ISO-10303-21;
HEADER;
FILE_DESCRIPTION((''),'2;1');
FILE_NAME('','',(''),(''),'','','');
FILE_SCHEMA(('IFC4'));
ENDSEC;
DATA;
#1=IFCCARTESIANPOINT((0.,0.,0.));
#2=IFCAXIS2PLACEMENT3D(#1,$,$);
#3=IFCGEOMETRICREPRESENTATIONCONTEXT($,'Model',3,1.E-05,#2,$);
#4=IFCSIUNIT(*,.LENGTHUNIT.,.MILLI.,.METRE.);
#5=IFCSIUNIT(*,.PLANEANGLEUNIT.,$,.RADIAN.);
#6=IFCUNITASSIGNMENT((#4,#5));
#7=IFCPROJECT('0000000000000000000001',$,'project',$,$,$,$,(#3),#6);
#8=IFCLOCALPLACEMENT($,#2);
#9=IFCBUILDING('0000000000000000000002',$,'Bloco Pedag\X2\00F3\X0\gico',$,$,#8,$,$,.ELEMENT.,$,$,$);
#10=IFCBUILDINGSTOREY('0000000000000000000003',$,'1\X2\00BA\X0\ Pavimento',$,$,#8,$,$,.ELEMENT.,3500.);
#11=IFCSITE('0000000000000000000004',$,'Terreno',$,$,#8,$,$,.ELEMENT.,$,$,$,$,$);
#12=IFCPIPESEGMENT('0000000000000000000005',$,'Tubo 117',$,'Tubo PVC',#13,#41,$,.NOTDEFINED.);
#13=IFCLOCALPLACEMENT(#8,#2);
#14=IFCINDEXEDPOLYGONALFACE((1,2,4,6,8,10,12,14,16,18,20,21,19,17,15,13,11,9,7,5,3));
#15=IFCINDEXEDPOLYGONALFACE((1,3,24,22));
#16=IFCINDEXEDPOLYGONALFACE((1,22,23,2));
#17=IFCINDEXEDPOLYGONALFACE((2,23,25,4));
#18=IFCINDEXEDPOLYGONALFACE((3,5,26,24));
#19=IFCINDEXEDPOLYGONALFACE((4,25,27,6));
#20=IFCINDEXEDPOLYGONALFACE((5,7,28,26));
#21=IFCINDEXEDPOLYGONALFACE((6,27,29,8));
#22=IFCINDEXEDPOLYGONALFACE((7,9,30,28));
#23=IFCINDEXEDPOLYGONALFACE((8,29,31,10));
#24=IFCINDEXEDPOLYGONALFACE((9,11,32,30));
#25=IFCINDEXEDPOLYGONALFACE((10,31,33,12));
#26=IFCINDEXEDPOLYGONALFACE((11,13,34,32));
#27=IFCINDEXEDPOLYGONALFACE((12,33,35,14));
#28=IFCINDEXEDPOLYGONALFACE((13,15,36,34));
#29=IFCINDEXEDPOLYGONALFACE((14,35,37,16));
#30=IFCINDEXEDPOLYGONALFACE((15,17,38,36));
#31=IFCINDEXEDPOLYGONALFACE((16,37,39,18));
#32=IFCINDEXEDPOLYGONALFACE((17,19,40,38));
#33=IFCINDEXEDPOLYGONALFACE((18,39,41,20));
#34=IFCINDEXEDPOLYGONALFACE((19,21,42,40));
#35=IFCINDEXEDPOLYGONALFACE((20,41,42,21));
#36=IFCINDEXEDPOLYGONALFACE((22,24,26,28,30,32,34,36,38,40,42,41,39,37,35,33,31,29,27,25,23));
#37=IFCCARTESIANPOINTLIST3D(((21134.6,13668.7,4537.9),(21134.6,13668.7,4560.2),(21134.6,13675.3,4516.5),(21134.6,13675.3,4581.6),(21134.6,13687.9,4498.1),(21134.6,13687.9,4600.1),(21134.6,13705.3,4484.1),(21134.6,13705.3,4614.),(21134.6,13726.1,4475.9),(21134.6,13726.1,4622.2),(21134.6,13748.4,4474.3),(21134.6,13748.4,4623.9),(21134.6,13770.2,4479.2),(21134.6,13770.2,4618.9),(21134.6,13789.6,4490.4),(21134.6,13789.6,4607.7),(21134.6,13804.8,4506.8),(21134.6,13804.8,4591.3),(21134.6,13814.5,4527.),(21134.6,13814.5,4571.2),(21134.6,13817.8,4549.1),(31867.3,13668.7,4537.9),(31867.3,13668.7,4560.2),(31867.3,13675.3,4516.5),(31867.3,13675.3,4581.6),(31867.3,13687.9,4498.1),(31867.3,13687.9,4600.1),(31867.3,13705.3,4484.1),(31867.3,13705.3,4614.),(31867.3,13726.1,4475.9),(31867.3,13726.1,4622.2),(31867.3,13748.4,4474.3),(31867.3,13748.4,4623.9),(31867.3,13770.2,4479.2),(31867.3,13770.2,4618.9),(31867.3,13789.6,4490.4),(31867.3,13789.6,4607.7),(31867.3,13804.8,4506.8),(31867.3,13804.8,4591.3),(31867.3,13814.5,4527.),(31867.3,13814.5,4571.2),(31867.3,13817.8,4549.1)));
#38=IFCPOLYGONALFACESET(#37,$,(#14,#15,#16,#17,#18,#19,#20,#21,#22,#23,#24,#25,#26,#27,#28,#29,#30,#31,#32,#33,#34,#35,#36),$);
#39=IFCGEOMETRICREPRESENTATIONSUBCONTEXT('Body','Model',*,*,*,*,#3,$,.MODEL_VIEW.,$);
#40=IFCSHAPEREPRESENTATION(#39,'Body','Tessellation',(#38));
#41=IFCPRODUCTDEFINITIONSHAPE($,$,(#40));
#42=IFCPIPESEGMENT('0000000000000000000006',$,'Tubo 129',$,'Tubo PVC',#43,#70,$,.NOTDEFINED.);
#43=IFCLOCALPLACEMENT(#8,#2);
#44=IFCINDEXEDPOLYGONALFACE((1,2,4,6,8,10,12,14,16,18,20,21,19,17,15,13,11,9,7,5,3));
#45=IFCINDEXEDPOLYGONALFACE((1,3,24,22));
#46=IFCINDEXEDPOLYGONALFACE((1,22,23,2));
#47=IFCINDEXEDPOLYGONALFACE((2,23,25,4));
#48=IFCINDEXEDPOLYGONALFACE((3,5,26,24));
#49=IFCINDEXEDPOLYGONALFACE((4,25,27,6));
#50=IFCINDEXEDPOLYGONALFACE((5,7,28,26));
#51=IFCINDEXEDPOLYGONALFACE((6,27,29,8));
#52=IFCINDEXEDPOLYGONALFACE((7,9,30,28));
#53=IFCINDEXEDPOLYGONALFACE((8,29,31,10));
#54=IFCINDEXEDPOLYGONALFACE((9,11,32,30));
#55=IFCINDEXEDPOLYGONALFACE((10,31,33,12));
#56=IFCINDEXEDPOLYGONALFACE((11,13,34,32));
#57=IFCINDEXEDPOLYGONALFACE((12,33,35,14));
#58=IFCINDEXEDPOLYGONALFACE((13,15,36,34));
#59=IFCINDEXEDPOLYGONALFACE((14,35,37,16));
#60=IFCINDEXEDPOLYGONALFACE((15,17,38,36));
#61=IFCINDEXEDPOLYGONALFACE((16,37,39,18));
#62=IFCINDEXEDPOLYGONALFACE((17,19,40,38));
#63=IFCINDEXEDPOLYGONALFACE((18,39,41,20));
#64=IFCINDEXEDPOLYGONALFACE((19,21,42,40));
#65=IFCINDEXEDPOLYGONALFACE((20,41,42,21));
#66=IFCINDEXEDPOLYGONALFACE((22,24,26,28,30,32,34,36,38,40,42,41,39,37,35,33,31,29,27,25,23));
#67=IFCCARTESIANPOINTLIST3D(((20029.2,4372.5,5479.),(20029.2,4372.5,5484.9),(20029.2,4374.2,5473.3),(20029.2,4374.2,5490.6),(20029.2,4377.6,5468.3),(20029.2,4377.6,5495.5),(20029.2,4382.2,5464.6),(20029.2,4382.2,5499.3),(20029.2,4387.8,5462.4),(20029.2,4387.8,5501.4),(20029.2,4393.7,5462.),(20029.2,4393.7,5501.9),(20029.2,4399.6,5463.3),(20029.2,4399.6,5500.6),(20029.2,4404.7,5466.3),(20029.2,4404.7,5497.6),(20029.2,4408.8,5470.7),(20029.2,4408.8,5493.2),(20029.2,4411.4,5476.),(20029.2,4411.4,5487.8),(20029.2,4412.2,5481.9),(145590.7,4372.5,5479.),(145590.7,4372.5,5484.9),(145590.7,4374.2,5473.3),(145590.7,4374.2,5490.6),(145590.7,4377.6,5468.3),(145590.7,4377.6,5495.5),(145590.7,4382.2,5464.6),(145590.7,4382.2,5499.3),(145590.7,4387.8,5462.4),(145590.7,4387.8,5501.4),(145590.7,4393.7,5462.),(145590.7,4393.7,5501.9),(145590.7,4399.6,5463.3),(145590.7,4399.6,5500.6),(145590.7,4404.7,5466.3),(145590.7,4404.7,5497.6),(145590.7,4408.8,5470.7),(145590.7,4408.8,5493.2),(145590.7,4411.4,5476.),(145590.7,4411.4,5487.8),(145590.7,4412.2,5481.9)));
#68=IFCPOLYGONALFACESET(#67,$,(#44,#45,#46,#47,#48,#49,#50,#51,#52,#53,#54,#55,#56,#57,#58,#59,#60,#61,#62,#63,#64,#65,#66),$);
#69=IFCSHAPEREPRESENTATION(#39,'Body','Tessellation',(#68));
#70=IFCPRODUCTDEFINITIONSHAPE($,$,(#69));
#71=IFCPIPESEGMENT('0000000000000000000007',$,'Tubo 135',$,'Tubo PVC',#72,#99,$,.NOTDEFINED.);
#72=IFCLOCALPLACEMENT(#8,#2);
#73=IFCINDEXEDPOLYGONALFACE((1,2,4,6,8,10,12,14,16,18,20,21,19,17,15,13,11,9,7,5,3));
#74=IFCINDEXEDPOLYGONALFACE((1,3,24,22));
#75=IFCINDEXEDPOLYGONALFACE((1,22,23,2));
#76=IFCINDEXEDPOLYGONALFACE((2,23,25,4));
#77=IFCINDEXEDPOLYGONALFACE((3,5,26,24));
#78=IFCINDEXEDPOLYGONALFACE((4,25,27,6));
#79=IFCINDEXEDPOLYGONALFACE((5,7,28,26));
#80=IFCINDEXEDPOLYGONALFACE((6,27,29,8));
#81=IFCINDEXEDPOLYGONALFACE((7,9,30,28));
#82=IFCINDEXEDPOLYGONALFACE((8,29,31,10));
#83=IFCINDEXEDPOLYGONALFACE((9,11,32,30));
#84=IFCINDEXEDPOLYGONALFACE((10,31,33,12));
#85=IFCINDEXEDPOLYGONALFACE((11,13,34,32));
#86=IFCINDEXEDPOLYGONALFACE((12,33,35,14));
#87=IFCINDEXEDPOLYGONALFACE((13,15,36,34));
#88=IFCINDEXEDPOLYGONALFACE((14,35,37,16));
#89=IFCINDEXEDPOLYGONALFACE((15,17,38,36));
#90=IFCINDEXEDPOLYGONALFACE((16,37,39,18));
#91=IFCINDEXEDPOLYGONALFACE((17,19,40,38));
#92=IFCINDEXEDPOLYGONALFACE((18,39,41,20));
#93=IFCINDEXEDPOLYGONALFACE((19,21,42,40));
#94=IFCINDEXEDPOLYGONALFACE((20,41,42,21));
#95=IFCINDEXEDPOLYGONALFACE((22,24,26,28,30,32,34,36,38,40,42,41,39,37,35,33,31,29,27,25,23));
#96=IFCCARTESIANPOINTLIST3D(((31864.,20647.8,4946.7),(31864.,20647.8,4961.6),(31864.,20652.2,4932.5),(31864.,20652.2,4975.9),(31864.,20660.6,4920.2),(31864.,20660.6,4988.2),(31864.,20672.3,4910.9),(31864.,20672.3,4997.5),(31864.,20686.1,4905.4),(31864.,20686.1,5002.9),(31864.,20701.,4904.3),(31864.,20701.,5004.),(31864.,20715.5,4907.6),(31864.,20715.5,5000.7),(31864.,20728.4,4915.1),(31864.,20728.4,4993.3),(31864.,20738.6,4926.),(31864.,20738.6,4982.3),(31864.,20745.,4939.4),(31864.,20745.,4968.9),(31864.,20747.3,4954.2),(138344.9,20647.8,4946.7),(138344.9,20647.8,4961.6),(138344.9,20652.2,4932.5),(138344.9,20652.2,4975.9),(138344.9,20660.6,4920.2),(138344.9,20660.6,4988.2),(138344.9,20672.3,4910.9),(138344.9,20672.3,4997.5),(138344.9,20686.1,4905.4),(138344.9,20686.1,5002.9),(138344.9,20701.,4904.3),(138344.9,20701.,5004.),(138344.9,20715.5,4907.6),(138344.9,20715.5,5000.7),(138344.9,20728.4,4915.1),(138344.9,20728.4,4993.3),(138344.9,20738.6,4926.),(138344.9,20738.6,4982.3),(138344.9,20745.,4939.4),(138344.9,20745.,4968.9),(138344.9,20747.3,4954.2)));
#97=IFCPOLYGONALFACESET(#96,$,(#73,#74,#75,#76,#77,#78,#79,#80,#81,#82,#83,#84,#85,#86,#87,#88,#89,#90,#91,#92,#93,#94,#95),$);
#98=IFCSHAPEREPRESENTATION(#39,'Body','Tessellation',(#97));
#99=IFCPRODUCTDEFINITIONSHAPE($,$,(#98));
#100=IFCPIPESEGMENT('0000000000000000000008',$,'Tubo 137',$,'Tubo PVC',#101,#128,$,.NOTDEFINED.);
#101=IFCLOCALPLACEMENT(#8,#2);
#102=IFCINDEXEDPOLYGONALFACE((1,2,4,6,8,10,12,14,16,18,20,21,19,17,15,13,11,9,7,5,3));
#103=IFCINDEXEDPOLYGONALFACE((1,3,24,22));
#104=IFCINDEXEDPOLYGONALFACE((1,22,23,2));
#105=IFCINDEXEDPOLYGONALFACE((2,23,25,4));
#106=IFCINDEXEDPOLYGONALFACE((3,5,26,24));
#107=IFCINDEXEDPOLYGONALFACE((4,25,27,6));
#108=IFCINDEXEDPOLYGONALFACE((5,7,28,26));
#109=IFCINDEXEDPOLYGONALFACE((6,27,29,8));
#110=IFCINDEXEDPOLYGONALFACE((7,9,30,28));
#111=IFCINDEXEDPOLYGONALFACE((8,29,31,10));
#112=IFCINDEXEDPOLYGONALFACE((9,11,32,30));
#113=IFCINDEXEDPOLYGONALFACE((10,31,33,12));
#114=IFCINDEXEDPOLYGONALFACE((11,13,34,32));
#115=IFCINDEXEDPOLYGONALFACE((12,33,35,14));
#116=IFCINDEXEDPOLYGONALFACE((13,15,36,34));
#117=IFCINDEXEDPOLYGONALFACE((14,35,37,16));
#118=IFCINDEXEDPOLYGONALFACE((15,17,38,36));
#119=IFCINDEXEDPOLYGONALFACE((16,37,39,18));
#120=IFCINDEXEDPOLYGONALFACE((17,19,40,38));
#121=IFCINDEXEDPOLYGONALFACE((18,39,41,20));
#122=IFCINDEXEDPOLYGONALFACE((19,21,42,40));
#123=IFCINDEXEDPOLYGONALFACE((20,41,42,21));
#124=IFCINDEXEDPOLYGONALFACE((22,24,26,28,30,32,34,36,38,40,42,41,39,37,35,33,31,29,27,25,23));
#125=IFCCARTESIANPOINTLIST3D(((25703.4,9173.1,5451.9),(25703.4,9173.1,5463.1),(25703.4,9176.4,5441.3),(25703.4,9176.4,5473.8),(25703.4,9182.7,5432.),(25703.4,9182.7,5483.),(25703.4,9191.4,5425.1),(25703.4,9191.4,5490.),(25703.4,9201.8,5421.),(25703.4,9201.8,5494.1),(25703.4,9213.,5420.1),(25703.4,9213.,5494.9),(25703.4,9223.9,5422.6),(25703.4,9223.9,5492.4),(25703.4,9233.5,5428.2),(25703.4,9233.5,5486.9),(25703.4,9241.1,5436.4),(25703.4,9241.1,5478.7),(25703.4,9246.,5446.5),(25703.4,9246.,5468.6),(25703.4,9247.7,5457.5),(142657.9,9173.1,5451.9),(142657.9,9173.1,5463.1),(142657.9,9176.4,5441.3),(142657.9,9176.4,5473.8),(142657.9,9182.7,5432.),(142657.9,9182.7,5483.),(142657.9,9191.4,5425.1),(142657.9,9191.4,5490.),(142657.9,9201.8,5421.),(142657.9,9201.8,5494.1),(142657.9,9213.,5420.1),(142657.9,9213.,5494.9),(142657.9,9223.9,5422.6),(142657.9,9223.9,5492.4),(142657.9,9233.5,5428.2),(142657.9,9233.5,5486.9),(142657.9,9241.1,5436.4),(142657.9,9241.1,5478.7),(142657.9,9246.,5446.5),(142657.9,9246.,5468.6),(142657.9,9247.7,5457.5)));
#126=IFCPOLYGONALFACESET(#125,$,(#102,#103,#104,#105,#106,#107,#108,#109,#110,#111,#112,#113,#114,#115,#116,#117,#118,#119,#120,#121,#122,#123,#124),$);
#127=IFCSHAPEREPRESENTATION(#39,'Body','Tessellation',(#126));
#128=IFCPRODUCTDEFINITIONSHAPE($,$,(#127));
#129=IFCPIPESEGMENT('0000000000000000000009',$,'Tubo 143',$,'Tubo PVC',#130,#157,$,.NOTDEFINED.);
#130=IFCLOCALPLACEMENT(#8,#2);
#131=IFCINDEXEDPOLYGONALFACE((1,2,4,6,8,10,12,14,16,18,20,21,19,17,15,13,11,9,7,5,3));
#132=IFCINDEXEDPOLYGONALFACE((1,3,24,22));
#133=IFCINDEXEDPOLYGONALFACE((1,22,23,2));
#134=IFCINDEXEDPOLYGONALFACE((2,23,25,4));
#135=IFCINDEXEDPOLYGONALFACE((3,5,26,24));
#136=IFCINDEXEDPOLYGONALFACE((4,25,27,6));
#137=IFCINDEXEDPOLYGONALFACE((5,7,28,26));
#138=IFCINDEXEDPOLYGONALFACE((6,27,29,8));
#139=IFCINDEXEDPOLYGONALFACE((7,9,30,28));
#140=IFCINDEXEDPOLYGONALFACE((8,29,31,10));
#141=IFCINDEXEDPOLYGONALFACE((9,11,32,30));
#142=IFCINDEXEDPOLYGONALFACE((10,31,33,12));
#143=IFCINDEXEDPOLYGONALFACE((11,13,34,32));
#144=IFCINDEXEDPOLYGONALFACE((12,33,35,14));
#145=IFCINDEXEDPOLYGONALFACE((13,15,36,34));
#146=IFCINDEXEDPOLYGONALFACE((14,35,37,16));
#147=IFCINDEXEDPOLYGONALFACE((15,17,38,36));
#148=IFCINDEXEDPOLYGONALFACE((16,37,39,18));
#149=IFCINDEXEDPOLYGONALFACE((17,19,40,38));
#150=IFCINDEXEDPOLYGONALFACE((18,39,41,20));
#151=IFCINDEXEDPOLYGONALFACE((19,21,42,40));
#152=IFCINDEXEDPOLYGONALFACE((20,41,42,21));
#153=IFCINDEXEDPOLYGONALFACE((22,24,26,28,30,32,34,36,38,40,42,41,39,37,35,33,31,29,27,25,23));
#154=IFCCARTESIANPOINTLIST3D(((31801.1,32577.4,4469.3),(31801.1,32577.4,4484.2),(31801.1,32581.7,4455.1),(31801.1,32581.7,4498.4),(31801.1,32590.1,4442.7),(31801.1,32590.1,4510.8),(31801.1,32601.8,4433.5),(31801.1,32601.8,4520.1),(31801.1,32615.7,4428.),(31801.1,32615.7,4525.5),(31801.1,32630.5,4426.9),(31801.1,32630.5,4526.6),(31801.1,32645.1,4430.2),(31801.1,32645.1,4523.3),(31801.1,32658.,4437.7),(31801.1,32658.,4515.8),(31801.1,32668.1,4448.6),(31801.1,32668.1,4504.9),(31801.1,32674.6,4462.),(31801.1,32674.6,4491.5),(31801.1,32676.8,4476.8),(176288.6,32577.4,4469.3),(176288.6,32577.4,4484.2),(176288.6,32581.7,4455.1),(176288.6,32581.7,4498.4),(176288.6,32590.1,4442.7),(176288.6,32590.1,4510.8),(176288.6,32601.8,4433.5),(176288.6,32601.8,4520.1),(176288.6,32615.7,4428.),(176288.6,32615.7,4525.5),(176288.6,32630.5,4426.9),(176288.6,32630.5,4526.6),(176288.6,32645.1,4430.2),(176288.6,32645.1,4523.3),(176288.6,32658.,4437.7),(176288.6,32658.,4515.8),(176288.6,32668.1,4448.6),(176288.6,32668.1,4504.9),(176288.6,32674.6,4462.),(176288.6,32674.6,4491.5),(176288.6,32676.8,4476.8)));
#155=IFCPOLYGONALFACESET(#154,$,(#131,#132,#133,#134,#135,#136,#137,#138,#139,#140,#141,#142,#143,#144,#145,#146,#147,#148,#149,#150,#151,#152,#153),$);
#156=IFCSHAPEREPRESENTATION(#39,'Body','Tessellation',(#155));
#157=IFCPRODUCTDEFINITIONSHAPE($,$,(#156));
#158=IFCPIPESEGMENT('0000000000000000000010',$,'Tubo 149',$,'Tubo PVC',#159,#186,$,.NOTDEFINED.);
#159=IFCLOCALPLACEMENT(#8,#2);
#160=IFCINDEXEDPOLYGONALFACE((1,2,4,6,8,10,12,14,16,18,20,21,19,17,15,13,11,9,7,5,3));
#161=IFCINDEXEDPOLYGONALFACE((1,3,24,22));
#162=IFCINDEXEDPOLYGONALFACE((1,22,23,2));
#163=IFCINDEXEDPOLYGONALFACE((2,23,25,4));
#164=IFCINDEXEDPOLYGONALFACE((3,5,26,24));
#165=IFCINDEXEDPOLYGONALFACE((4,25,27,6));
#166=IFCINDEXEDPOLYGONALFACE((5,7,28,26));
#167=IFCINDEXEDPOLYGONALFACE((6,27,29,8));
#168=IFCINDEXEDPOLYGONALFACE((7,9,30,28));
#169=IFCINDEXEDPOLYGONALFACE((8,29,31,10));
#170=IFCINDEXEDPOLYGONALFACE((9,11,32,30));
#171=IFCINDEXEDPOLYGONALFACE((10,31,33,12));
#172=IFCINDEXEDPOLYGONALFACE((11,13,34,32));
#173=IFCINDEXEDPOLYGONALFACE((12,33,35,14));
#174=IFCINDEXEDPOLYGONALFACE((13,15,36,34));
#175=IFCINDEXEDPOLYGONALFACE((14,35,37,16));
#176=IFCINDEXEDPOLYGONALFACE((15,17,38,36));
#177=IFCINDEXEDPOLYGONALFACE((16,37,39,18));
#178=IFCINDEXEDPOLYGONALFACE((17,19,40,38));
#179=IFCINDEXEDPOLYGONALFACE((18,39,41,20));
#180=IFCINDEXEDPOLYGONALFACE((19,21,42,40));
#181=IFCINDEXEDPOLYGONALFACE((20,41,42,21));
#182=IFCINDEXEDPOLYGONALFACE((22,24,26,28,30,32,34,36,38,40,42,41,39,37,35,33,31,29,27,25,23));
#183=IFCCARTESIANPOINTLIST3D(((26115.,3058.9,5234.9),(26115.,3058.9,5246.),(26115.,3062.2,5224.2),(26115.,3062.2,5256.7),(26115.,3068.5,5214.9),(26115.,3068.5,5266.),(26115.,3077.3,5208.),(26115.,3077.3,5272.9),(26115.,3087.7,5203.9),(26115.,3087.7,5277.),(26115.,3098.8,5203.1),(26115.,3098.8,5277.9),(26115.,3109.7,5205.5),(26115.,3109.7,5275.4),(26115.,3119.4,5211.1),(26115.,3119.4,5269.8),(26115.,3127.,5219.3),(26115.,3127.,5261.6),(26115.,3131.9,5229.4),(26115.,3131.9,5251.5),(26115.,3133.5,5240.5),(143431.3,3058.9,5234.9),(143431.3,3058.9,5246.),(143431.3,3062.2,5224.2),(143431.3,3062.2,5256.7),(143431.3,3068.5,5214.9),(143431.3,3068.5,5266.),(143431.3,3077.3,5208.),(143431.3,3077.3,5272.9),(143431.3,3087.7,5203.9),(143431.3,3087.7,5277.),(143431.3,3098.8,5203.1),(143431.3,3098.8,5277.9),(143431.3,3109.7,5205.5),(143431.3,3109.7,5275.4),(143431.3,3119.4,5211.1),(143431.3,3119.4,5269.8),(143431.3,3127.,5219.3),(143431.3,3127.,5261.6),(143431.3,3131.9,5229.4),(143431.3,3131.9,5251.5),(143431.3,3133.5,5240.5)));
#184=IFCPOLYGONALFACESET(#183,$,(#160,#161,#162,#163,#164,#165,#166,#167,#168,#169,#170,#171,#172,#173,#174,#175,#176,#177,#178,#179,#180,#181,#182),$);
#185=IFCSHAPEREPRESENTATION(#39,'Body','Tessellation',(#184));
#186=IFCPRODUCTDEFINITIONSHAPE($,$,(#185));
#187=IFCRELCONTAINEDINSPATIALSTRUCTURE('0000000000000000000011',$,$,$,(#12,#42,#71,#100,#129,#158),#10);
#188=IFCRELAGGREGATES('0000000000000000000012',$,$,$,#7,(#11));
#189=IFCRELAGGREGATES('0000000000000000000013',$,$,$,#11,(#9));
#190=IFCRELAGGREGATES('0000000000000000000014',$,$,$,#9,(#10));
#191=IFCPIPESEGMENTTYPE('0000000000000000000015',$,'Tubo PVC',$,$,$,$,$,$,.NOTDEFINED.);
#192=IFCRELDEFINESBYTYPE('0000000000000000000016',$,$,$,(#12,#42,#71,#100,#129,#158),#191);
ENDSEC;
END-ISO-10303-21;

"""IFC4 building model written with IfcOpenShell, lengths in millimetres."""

from ifc_helpers import new_model, si_unit, frame, origin, origin_2d, place, context, subcontext, project, spatial, circle, extrude, type_object, element, save


model = new_model("IFC4")

# Units and contexts
model_context = context("Model", 3, precision=1e-05, world=origin())
body_context = subcontext(model_context, "Body", "Model", "MODEL_VIEW")
ifc_project = project(units=[si_unit("LENGTHUNIT", "METRE", prefix="MILLI"), si_unit("PLANEANGLEUNIT", "RADIAN")], contexts=[model_context])

# Site, building, storey
placement = place(None, origin())
site = spatial("IfcSite", under=ifc_project, at=placement, Name="Terreno", CompositionType="ELEMENT")
building = spatial("IfcBuilding", under=site, at=placement, Name="Bloco Pedagógico", CompositionType="ELEMENT")
storey = spatial("IfcBuildingStorey", under=building, at=placement, Name="1º Pavimento", CompositionType="ELEMENT", Elevation=3500.0)

# Pipe segments
pipe_segment_type = type_object("IfcPipeSegmentType", Name="Tubo PVC", PredefinedType="NOTDEFINED")
pipe_segment_1_placement = place(None, frame((21134.6, 13742.8, 4549.1), z_axis=(1.0, 0.0, 0.0), x_axis=(0.0, 1.0, 0.0)))
element("IfcPipeSegment", 1, at=pipe_segment_1_placement, inside=storey, type_object=pipe_segment_type, Name="Tubo 117", ObjectType="Tubo PVC", PredefinedType="NOTDEFINED", context=body_context, shape_type="SweptSolid", body=[
    extrude(circle(Radius=75.0, at=origin_2d()), None, (0.0, 0.0, 1.0), 10732.7),
])
pipe_segment_2_placement = place(None, frame((20029.2, 4392.2, 5481.9), z_axis=(1.0, 0.0, 0.0), x_axis=(0.0, 1.0, 0.0)))
element("IfcPipeSegment", 2, at=pipe_segment_2_placement, inside=storey, type_object=pipe_segment_type, Name="Tubo 129", ObjectType="Tubo PVC", PredefinedType="NOTDEFINED", context=body_context, shape_type="SweptSolid", body=[
    extrude(circle(Radius=20.0, at=origin_2d()), None, (0.0, 0.0, 1.0), 125561.5),
])
pipe_segment_3_placement = place(None, frame((31864.0, 20697.3, 4954.2), z_axis=(1.0, 0.0, 0.0), x_axis=(0.0, 1.0, 0.0)))
element("IfcPipeSegment", 3, at=pipe_segment_3_placement, inside=storey, type_object=pipe_segment_type, Name="Tubo 135", ObjectType="Tubo PVC", PredefinedType="NOTDEFINED", context=body_context, shape_type="SweptSolid", body=[
    extrude(circle(Radius=50.0, at=origin_2d()), None, (0.0, 0.0, 1.0), 106480.8),
])
pipe_segment_4_placement = place(None, frame((25703.4, 9210.2, 5457.5), z_axis=(1.0, 0.0, 0.0), x_axis=(0.0, 1.0, 0.0)))
element("IfcPipeSegment", 4, at=pipe_segment_4_placement, inside=storey, type_object=pipe_segment_type, Name="Tubo 137", ObjectType="Tubo PVC", PredefinedType="NOTDEFINED", context=body_context, shape_type="SweptSolid", body=[
    extrude(circle(Radius=37.5, at=origin_2d()), None, (0.0, 0.0, 1.0), 116954.5),
])
pipe_segment_5_placement = place(None, frame((31801.1, 32626.8, 4476.8), z_axis=(1.0, 0.0, 0.0), x_axis=(0.0, 1.0, 0.0)))
element("IfcPipeSegment", 5, at=pipe_segment_5_placement, inside=storey, type_object=pipe_segment_type, Name="Tubo 143", ObjectType="Tubo PVC", PredefinedType="NOTDEFINED", context=body_context, shape_type="SweptSolid", body=[
    extrude(circle(Radius=50.0, at=origin_2d()), None, (0.0, 0.0, 1.0), 144487.5),
])
pipe_segment_6_placement = place(None, frame((26115.0, 3096.0, 5240.5), z_axis=(1.0, 0.0, 0.0), x_axis=(0.0, 1.0, 0.0)))
element("IfcPipeSegment", 6, at=pipe_segment_6_placement, inside=storey, type_object=pipe_segment_type, Name="Tubo 149", ObjectType="Tubo PVC", PredefinedType="NOTDEFINED", context=body_context, shape_type="SweptSolid", body=[
    extrude(circle(Radius=37.5, at=origin_2d()), None, (0.0, 0.0, 1.0), 117316.3),
])

save(model, "model.ifc")
